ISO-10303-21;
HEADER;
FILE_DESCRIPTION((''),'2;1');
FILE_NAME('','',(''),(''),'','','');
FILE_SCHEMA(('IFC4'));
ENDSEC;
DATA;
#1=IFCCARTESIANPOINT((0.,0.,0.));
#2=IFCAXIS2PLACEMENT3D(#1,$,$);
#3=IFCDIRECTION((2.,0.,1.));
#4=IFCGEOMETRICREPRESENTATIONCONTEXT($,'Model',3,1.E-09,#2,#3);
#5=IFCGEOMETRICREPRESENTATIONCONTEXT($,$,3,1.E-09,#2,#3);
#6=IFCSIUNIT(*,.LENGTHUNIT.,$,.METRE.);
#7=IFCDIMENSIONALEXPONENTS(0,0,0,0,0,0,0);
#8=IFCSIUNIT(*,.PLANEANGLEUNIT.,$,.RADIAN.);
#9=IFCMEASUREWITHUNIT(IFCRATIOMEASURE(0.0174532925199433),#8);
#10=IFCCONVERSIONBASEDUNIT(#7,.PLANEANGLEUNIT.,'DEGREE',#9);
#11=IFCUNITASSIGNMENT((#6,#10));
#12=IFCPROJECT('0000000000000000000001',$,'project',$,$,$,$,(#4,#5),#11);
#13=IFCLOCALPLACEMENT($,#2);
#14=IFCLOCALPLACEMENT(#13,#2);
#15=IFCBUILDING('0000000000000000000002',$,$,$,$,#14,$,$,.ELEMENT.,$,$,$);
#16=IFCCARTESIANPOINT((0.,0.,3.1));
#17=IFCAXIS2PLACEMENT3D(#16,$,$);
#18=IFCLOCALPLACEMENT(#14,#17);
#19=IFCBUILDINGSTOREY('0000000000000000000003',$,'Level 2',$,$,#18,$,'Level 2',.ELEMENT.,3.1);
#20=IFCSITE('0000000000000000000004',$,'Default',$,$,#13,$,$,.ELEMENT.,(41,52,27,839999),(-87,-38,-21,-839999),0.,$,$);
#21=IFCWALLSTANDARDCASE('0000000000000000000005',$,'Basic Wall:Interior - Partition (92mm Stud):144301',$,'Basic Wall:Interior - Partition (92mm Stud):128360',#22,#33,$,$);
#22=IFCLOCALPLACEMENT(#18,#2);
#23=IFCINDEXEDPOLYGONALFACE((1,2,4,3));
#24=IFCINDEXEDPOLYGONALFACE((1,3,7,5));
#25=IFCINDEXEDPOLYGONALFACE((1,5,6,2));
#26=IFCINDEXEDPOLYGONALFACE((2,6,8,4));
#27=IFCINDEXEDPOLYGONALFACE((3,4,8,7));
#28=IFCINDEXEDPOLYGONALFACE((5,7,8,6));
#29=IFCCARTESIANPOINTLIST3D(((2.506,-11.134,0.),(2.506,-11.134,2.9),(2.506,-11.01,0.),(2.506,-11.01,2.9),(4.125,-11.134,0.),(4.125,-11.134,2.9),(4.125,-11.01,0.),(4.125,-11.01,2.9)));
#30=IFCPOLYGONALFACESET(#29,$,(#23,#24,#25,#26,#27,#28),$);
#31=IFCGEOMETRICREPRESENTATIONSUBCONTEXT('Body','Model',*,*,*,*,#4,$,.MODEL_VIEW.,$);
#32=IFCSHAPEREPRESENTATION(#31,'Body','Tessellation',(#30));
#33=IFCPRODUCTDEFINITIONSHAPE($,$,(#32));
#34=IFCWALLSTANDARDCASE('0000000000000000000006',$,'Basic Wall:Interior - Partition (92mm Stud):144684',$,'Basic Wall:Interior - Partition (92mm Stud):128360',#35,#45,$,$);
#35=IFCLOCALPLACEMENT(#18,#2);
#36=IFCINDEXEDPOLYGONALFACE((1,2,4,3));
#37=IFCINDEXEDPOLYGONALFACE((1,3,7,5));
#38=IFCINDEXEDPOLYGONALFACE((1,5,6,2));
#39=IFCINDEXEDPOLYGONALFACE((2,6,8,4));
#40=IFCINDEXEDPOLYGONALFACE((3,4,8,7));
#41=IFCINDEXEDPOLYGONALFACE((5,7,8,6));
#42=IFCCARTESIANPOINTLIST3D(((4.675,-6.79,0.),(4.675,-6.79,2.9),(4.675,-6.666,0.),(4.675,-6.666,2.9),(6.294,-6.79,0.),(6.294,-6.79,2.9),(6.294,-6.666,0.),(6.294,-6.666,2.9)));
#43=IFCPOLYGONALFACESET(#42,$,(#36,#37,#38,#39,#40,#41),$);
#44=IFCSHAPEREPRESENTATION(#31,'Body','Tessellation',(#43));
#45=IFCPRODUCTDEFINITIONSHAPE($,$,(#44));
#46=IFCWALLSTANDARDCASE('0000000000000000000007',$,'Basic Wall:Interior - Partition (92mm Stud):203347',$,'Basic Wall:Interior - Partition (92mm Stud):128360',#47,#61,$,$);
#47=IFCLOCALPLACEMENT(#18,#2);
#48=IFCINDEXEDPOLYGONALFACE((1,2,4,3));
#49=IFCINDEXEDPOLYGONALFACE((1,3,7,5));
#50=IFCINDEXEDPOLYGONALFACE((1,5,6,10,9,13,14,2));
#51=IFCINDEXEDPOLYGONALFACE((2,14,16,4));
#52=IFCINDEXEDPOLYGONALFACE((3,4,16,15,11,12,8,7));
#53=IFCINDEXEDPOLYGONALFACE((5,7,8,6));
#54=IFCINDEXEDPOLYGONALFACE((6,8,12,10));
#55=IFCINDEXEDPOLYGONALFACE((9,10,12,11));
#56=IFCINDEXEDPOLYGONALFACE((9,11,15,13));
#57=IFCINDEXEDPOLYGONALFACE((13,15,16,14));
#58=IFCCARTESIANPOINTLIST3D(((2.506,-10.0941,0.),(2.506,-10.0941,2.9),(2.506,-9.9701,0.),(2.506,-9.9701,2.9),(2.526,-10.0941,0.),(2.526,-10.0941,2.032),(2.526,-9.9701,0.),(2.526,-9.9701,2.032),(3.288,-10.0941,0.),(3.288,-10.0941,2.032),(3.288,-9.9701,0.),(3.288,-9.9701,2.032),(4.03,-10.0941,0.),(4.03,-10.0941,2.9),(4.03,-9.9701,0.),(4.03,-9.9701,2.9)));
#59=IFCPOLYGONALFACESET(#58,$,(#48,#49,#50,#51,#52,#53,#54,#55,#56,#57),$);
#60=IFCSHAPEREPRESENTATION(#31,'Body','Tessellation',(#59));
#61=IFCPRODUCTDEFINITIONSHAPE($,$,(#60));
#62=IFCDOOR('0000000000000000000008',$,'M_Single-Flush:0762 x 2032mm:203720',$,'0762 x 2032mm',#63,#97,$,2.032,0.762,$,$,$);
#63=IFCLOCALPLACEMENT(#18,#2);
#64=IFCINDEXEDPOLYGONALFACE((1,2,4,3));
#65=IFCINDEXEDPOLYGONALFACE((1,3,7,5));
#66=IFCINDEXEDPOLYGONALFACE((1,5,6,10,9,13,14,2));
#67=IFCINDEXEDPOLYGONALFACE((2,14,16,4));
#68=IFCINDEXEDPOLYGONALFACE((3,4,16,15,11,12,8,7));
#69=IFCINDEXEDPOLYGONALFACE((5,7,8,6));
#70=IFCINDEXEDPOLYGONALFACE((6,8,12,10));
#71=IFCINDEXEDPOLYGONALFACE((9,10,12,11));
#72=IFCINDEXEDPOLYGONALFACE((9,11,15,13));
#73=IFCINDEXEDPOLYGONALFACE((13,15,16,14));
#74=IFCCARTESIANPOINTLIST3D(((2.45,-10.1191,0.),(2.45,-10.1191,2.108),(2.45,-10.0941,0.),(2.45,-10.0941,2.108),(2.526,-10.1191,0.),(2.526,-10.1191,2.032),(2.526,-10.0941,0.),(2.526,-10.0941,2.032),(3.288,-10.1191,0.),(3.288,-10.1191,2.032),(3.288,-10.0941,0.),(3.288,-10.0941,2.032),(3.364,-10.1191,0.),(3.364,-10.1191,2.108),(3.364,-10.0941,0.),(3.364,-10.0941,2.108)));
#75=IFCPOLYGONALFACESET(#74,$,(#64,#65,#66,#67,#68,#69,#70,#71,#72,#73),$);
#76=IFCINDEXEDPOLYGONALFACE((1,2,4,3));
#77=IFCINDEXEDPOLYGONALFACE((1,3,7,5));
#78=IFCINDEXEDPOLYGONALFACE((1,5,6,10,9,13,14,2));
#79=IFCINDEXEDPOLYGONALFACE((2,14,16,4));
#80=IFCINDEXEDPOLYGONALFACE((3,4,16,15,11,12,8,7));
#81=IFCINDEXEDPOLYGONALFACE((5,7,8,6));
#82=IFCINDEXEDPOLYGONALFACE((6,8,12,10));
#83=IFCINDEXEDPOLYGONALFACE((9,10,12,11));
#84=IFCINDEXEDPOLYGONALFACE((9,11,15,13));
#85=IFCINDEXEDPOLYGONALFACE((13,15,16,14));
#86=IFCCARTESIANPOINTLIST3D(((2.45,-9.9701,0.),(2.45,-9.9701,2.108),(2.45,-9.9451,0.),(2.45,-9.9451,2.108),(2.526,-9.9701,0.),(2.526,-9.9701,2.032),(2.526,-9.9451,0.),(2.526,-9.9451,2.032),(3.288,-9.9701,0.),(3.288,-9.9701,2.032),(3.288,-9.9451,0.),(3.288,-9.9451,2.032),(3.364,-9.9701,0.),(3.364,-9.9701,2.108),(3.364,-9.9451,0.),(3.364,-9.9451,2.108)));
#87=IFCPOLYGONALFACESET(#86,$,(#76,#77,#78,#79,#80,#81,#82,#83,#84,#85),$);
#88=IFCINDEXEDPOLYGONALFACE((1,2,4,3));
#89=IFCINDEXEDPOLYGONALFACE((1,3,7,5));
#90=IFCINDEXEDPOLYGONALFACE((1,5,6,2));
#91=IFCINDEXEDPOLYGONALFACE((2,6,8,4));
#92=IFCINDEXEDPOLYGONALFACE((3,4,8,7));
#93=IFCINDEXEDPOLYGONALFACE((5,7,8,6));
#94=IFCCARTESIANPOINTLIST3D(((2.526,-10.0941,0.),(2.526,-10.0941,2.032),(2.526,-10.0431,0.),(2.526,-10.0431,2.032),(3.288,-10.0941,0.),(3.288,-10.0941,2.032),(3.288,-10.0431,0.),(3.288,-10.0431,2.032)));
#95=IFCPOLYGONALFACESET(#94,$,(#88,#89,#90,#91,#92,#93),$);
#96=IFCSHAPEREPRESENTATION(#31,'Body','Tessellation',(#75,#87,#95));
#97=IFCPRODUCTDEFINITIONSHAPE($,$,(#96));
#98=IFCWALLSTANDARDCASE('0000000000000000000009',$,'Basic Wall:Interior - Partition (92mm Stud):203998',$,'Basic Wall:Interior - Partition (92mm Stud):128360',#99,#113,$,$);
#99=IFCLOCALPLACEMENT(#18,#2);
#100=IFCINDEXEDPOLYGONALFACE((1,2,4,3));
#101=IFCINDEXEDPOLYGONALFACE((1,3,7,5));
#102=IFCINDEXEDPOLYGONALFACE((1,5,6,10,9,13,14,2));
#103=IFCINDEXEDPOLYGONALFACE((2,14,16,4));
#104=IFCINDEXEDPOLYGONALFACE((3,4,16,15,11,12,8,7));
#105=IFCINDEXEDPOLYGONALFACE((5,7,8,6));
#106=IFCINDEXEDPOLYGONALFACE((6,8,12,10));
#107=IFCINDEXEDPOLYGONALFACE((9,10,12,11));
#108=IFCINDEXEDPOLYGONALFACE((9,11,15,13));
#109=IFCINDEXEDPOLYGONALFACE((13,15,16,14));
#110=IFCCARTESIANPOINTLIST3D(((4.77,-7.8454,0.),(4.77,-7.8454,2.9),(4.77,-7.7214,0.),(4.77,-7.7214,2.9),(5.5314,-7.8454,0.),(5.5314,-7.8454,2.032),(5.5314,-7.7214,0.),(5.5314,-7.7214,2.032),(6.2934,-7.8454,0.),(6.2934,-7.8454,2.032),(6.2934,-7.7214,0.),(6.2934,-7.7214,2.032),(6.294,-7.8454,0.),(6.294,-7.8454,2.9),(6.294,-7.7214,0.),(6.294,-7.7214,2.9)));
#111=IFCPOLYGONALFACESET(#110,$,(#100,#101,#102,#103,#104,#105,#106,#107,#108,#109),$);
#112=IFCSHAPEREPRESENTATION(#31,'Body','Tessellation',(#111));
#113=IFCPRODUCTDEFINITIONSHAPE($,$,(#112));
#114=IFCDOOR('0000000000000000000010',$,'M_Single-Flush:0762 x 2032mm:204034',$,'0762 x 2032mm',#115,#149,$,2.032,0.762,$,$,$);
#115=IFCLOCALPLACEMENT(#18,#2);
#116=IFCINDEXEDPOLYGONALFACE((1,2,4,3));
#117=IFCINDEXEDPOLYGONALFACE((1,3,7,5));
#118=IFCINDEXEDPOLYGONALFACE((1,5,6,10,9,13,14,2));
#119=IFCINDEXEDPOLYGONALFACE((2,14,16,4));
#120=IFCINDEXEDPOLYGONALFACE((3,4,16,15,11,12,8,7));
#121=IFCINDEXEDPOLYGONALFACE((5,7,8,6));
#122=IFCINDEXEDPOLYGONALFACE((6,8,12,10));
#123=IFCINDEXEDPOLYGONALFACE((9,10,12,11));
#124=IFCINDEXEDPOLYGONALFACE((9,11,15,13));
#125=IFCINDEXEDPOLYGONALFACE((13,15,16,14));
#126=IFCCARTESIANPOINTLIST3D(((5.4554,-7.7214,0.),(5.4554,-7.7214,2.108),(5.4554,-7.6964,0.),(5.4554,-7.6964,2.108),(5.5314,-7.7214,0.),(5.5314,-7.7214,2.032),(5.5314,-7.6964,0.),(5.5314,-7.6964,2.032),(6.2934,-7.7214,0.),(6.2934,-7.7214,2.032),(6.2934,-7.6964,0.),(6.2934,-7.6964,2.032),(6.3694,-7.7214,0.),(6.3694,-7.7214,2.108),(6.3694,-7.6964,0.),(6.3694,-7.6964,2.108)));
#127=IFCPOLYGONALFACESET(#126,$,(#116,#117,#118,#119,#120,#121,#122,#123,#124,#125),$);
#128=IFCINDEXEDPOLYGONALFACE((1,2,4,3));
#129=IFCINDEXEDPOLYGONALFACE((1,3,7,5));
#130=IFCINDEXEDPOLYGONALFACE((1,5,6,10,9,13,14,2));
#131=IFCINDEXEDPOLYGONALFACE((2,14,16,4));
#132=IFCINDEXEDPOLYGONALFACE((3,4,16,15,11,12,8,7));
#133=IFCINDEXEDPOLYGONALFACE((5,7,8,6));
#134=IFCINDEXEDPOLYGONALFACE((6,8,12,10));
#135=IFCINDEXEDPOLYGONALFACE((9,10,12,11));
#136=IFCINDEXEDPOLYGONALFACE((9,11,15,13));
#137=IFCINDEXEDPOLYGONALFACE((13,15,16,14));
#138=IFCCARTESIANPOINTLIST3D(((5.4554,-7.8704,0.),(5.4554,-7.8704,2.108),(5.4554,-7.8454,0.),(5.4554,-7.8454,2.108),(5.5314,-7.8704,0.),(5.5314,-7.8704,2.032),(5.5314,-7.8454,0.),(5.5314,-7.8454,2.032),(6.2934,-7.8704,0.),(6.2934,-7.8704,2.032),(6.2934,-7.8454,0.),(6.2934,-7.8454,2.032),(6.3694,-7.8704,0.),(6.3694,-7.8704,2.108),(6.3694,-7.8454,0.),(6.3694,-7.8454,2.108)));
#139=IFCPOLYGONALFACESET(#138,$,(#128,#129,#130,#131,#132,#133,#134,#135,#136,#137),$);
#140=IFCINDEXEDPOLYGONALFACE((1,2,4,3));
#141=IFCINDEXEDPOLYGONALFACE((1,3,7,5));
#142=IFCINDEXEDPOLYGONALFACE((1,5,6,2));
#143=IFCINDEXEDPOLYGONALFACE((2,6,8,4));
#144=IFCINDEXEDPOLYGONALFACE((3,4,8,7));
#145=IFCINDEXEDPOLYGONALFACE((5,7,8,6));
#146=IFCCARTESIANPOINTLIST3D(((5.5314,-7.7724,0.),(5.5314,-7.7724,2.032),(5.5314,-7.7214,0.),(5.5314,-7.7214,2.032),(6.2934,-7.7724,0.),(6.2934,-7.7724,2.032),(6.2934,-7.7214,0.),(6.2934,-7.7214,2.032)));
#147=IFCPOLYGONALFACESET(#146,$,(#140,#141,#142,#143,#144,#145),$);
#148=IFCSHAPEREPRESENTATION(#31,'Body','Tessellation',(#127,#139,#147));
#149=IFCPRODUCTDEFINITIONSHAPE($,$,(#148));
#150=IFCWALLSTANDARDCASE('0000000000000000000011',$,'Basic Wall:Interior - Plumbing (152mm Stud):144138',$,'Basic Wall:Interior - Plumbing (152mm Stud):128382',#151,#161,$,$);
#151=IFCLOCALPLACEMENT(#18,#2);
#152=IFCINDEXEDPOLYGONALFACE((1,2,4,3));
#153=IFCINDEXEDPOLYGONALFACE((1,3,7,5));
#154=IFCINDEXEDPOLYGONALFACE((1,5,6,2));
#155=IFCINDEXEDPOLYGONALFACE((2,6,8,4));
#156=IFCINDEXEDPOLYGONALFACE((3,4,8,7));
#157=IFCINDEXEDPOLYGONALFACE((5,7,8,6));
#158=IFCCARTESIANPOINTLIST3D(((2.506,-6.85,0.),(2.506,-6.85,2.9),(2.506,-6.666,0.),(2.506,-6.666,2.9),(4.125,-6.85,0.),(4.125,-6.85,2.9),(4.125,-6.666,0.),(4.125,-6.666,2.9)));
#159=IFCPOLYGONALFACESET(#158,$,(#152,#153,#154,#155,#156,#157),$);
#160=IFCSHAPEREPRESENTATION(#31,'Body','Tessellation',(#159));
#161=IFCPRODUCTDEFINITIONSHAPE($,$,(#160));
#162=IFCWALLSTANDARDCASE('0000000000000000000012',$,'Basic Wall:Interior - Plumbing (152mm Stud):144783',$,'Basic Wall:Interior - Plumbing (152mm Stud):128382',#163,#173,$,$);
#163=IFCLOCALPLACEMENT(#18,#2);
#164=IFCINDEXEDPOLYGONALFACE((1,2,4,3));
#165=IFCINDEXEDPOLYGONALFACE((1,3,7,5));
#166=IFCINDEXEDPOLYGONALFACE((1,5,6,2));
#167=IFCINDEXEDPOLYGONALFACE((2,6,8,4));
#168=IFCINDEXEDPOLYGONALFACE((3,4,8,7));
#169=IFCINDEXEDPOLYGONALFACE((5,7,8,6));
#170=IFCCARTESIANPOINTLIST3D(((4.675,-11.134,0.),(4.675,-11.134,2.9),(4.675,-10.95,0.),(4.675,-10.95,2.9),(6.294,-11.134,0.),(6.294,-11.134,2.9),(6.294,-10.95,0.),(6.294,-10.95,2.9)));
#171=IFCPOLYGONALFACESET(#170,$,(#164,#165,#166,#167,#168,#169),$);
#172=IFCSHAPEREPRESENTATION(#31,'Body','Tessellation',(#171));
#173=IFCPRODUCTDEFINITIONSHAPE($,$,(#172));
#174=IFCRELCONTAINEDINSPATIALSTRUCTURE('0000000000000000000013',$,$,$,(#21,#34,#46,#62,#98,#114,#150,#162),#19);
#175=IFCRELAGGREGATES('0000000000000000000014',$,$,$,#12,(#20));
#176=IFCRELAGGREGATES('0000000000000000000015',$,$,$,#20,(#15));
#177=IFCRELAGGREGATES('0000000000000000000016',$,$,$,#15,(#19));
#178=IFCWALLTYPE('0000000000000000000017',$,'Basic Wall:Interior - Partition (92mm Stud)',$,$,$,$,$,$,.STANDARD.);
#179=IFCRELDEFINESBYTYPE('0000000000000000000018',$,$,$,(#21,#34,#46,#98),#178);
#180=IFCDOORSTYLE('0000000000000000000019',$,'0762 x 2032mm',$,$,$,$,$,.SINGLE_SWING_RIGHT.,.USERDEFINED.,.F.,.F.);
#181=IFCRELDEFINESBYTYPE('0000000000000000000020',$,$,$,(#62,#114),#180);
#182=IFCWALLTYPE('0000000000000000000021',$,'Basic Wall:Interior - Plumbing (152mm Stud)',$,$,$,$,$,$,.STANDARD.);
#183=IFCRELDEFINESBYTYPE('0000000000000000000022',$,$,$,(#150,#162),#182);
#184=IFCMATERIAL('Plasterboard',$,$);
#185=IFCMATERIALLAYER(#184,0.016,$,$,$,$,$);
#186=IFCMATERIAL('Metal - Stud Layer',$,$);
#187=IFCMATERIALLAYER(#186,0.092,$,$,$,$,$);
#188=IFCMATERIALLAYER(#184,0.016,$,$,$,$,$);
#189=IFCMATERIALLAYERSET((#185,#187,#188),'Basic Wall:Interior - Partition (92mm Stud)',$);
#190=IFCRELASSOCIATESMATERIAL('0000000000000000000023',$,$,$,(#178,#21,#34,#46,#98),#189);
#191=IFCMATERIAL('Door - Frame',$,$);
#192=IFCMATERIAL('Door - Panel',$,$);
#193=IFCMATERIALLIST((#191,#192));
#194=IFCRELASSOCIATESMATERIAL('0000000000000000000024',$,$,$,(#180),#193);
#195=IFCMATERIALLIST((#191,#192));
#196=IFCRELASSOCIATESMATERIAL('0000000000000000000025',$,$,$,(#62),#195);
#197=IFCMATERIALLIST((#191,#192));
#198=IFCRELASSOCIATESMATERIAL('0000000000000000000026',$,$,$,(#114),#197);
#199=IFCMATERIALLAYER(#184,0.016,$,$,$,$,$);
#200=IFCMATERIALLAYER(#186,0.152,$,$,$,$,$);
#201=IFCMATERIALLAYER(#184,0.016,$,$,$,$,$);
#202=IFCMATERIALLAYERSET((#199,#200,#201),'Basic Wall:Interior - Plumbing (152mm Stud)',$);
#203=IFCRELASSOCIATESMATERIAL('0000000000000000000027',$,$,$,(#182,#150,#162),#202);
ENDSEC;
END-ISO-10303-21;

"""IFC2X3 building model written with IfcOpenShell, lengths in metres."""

from ifc_helpers import new_model, entity, si_unit, converted_unit, direction, frame, frame_2d, origin, origin_2d_with_axis, place, context, subcontext, project, spatial, polyline, rectangle, outline, extrude, source, transform, mapped, material, material_list, layer, layer_set, layer_usage, type_object, type_shapes, element, fill, save


model = new_model("IFC2X3")

# Units and contexts
model_context = context("Model", 3, precision=1e-09, world=origin(), true_north=direction((2.0, 0.0, 1.0)))
context_of_model = context(None, 3, precision=1e-09, world=origin(), true_north=direction((2.0, 0.0, 1.0)))
body_context = subcontext(model_context, "Body", "Model", "MODEL_VIEW")
ifc_project = project(units=[si_unit("LENGTHUNIT", "METRE"), converted_unit("PLANEANGLEUNIT", "DEGREE", entity("IfcRatioMeasure", 0.0174532925199433), si_unit("PLANEANGLEUNIT", "RADIAN"), dimensions=[0, 0, 0, 0, 0, 0, 0])], contexts=[model_context, context_of_model])

# Site, building, storey
site_placement = place(None, origin())
site = spatial("IfcSite", under=ifc_project, at=site_placement, Name="Default", CompositionType="ELEMENT", RefLatitude=(41, 52, 27, 839999), RefLongitude=(-87, -38, -21, -839999), RefElevation=0.0)
building_placement = place(site_placement, origin())
building = spatial("IfcBuilding", under=site, at=building_placement, CompositionType="ELEMENT")
storey_placement = place(building_placement, frame((0.0, 0.0, 3.1)))
storey = spatial("IfcBuildingStorey", under=building, at=storey_placement, Name="Level 2", LongName="Level 2", CompositionType="ELEMENT", Elevation=3.1)

# Walls
ifc_material_1 = material(Name="Plasterboard")
ifc_layer_1 = layer(ifc_material_1, 0.016)
ifc_material_2 = material(Name="Metal - Stud Layer")
ifc_layer_2 = layer(ifc_material_2, 0.092)
ifc_layer_3 = layer(ifc_material_1, 0.016)
ifc_layer_set_1 = layer_set([ifc_layer_1, ifc_layer_2, ifc_layer_3], Name="Basic Wall:Interior - Partition (92mm Stud)")
ifc_layer_usage_1 = layer_usage(ifc_layer_set_1, "AXIS2", "NEGATIVE", 0.062)
wall_type_1 = type_object("IfcWallType", Name="Basic Wall:Interior - Partition (92mm Stud)", PredefinedType="STANDARD", material=ifc_layer_set_1)
wall_1_placement = place(storey_placement, frame((4.125, -11.072, 0.0), z_axis=(0.0, 0.0, 1.0), x_axis=(-1.0, 0.0, 0.0)))
element("IfcWallStandardCase", 1, at=wall_1_placement, inside=storey, type_object=wall_type_1, material=ifc_layer_usage_1, Name="Basic Wall:Interior - Partition (92mm Stud):144301", ObjectType="Basic Wall:Interior - Partition (92mm Stud):128360", context=body_context, shape_type="SweptSolid", body=[
    extrude(rectangle(XDim=1.619, YDim=0.124, at=frame_2d((0.8095, 0.0), x_axis=(-1.0, 0.0))), origin(), (0.0, 0.0, 1.0), 2.9),
])
ifc_layer_usage_2 = layer_usage(ifc_layer_set_1, "AXIS2", "NEGATIVE", 0.062)
wall_2_placement = place(storey_placement, frame((4.675, -6.728, 0.0)))
element("IfcWallStandardCase", 2, at=wall_2_placement, inside=storey, type_object=wall_type_1, material=ifc_layer_usage_2, Name="Basic Wall:Interior - Partition (92mm Stud):144684", ObjectType="Basic Wall:Interior - Partition (92mm Stud):128360", context=body_context, shape_type="SweptSolid", body=[
    extrude(rectangle(XDim=1.619, YDim=0.124, at=frame_2d((0.8095, 0.0), x_axis=(-1.0, 0.0))), origin(), (0.0, 0.0, 1.0), 2.9),
])

# Walls, openings, doors
ifc_layer_usage_3 = layer_usage(ifc_layer_set_1, "AXIS2", "NEGATIVE", 0.062)
wall_3_placement = place(storey_placement, frame((4.03, -10.0321, 0.0), z_axis=(0.0, 0.0, 1.0), x_axis=(-1.0, 0.0, 0.0)))
wall_3 = element("IfcWallStandardCase", 3, at=wall_3_placement, inside=storey, type_object=wall_type_1, material=ifc_layer_usage_3, Name="Basic Wall:Interior - Partition (92mm Stud):203347", ObjectType="Basic Wall:Interior - Partition (92mm Stud):128360", context=body_context, shape_type="SweptSolid", body=[
    extrude(rectangle(XDim=1.524, YDim=0.124, at=frame_2d((0.762, 0.0), x_axis=(-1.0, 0.0))), origin(), (0.0, 0.0, 1.0), 2.9),
])
opening_1_placement = place(wall_3_placement, frame((0.742, -0.062, 0.0)))
opening_1 = element("IfcOpeningElement", 4, at=opening_1_placement, cuts=wall_3, ObjectType="Opening", context=body_context, shape_type="SweptSolid", body=[
    extrude(rectangle(XDim=0.762, YDim=2.032, at=frame_2d((1.016, 0.381), x_axis=(0.0, 1.0))), frame((0.0, 0.0, 0.0), z_axis=(0.0, 1.0, 0.0), x_axis=(0.0, 0.0, 1.0)), (0.0, 0.0, 1.0), 0.124),
])
ifc_material_3 = material(Name="Door - Frame")
ifc_material_4 = material(Name="Door - Panel")
ifc_material_list_1 = material_list([ifc_material_3, ifc_material_4])
ifc_material_list_2 = material_list([ifc_material_3, ifc_material_4])
door_style = type_object("IfcDoorStyle", Name="0762 x 2032mm", ConstructionType="USERDEFINED", OperationType="SINGLE_SWING_RIGHT", ParameterTakesPrecedence=False, Sizeable=False, material=ifc_material_list_2)
shared_shape_1 = source(origin(), body_context, "Body", "SweptSolid", [
    extrude(outline(polyline([(-0.457, -1.073), (0.457, -1.073), (0.457, 1.035), (0.381, 1.035), (0.381, -0.997), (-0.381, -0.997), (-0.381, 1.035), (-0.457, 1.035), (-0.457, -1.073)])), frame((0.381, 0.124, 1.035), z_axis=(0.0, 1.0, 0.0), x_axis=(1.0, 0.0, 0.0)), (0.0, 0.0, 1.0), 0.025),
    extrude(outline(polyline([(-1.073, -0.457), (1.035, -0.457), (1.035, -0.381), (-0.997, -0.381), (-0.997, 0.381), (1.035, 0.381), (1.035, 0.457), (-1.073, 0.457), (-1.073, -0.457)])), frame((0.381, -0.025, 1.035), z_axis=(0.0, 1.0, 0.0), x_axis=(0.0, 0.0, -1.0)), (0.0, 0.0, 1.0), 0.025),
    extrude(rectangle(XDim=0.051, YDim=0.762, at=origin_2d_with_axis()), frame((0.381, 0.0985, 0.0), z_axis=(0.0, 0.0, 1.0), x_axis=(0.0, 1.0, 0.0)), (0.0, 0.0, 1.0), 2.032),
])
type_shapes(door_style, [shared_shape_1])
door_1_placement = place(opening_1_placement, origin())
door_1 = element("IfcDoor", 5, at=door_1_placement, inside=storey, type_object=door_style, material=ifc_material_list_1, Name="M_Single-Flush:0762 x 2032mm:203720", ObjectType="0762 x 2032mm", OverallHeight=2.032, OverallWidth=0.762, context=body_context, shape_type="MappedRepresentation", body=[
    mapped(shared_shape_1, transform((0.0, 0.0, 0.0), scale=1.0)),
])
fill(opening_1, door_1)
ifc_layer_usage_4 = layer_usage(ifc_layer_set_1, "AXIS2", "POSITIVE", -0.062)
wall_4_placement = place(storey_placement, frame((4.77, -7.7834, 0.0)))
wall_4 = element("IfcWallStandardCase", 6, at=wall_4_placement, inside=storey, type_object=wall_type_1, material=ifc_layer_usage_4, Name="Basic Wall:Interior - Partition (92mm Stud):203998", ObjectType="Basic Wall:Interior - Partition (92mm Stud):128360", context=body_context, shape_type="SweptSolid", body=[
    extrude(rectangle(XDim=1.524, YDim=0.124, at=frame_2d((0.762, 0.0), x_axis=(-1.0, 0.0))), origin(), (0.0, 0.0, 1.0), 2.9),
])
opening_2_placement = place(wall_4_placement, frame((0.7614, -0.062, 0.0)))
opening_2 = element("IfcOpeningElement", 7, at=opening_2_placement, cuts=wall_4, ObjectType="Opening", context=body_context, shape_type="SweptSolid", body=[
    extrude(rectangle(XDim=0.762, YDim=2.032, at=frame_2d((1.016, 0.381), x_axis=(0.0, 1.0))), frame((0.0, 0.0, 0.0), z_axis=(0.0, 1.0, 0.0), x_axis=(0.0, 0.0, 1.0)), (0.0, 0.0, 1.0), 0.124),
])
ifc_material_list_3 = material_list([ifc_material_3, ifc_material_4])
door_2_placement = place(opening_2_placement, origin())
door_2 = element("IfcDoor", 8, at=door_2_placement, inside=storey, type_object=door_style, material=ifc_material_list_3, Name="M_Single-Flush:0762 x 2032mm:204034", ObjectType="0762 x 2032mm", OverallHeight=2.032, OverallWidth=0.762, context=body_context, shape_type="MappedRepresentation", body=[
    mapped(shared_shape_1, transform((0.0, 0.0, 0.0), scale=1.0)),
])
fill(opening_2, door_2)

# Walls
ifc_layer_4 = layer(ifc_material_1, 0.016)
ifc_layer_5 = layer(ifc_material_2, 0.152)
ifc_layer_6 = layer(ifc_material_1, 0.016)
ifc_layer_set_2 = layer_set([ifc_layer_4, ifc_layer_5, ifc_layer_6], Name="Basic Wall:Interior - Plumbing (152mm Stud)")
ifc_layer_usage_5 = layer_usage(ifc_layer_set_2, "AXIS2", "NEGATIVE", 0.092)
wall_type_2 = type_object("IfcWallType", Name="Basic Wall:Interior - Plumbing (152mm Stud)", PredefinedType="STANDARD", material=ifc_layer_set_2)
wall_5_placement = place(storey_placement, frame((2.506, -6.758, 0.0)))
element("IfcWallStandardCase", 9, at=wall_5_placement, inside=storey, type_object=wall_type_2, material=ifc_layer_usage_5, Name="Basic Wall:Interior - Plumbing (152mm Stud):144138", ObjectType="Basic Wall:Interior - Plumbing (152mm Stud):128382", context=body_context, shape_type="SweptSolid", body=[
    extrude(rectangle(XDim=1.619, YDim=0.184, at=frame_2d((0.8095, 0.0), x_axis=(-1.0, 0.0))), origin(), (0.0, 0.0, 1.0), 2.9),
])
ifc_layer_usage_6 = layer_usage(ifc_layer_set_2, "AXIS2", "NEGATIVE", 0.092)
wall_6_placement = place(storey_placement, frame((6.294, -11.042, 0.0), z_axis=(0.0, 0.0, 1.0), x_axis=(-1.0, 0.0, 0.0)))
element("IfcWallStandardCase", 10, at=wall_6_placement, inside=storey, type_object=wall_type_2, material=ifc_layer_usage_6, Name="Basic Wall:Interior - Plumbing (152mm Stud):144783", ObjectType="Basic Wall:Interior - Plumbing (152mm Stud):128382", context=body_context, shape_type="SweptSolid", body=[
    extrude(rectangle(XDim=1.619, YDim=0.184, at=frame_2d((0.8095, 0.0), x_axis=(-1.0, 0.0))), origin(), (0.0, 0.0, 1.0), 2.9),
])

save(model, "model.ifc")
